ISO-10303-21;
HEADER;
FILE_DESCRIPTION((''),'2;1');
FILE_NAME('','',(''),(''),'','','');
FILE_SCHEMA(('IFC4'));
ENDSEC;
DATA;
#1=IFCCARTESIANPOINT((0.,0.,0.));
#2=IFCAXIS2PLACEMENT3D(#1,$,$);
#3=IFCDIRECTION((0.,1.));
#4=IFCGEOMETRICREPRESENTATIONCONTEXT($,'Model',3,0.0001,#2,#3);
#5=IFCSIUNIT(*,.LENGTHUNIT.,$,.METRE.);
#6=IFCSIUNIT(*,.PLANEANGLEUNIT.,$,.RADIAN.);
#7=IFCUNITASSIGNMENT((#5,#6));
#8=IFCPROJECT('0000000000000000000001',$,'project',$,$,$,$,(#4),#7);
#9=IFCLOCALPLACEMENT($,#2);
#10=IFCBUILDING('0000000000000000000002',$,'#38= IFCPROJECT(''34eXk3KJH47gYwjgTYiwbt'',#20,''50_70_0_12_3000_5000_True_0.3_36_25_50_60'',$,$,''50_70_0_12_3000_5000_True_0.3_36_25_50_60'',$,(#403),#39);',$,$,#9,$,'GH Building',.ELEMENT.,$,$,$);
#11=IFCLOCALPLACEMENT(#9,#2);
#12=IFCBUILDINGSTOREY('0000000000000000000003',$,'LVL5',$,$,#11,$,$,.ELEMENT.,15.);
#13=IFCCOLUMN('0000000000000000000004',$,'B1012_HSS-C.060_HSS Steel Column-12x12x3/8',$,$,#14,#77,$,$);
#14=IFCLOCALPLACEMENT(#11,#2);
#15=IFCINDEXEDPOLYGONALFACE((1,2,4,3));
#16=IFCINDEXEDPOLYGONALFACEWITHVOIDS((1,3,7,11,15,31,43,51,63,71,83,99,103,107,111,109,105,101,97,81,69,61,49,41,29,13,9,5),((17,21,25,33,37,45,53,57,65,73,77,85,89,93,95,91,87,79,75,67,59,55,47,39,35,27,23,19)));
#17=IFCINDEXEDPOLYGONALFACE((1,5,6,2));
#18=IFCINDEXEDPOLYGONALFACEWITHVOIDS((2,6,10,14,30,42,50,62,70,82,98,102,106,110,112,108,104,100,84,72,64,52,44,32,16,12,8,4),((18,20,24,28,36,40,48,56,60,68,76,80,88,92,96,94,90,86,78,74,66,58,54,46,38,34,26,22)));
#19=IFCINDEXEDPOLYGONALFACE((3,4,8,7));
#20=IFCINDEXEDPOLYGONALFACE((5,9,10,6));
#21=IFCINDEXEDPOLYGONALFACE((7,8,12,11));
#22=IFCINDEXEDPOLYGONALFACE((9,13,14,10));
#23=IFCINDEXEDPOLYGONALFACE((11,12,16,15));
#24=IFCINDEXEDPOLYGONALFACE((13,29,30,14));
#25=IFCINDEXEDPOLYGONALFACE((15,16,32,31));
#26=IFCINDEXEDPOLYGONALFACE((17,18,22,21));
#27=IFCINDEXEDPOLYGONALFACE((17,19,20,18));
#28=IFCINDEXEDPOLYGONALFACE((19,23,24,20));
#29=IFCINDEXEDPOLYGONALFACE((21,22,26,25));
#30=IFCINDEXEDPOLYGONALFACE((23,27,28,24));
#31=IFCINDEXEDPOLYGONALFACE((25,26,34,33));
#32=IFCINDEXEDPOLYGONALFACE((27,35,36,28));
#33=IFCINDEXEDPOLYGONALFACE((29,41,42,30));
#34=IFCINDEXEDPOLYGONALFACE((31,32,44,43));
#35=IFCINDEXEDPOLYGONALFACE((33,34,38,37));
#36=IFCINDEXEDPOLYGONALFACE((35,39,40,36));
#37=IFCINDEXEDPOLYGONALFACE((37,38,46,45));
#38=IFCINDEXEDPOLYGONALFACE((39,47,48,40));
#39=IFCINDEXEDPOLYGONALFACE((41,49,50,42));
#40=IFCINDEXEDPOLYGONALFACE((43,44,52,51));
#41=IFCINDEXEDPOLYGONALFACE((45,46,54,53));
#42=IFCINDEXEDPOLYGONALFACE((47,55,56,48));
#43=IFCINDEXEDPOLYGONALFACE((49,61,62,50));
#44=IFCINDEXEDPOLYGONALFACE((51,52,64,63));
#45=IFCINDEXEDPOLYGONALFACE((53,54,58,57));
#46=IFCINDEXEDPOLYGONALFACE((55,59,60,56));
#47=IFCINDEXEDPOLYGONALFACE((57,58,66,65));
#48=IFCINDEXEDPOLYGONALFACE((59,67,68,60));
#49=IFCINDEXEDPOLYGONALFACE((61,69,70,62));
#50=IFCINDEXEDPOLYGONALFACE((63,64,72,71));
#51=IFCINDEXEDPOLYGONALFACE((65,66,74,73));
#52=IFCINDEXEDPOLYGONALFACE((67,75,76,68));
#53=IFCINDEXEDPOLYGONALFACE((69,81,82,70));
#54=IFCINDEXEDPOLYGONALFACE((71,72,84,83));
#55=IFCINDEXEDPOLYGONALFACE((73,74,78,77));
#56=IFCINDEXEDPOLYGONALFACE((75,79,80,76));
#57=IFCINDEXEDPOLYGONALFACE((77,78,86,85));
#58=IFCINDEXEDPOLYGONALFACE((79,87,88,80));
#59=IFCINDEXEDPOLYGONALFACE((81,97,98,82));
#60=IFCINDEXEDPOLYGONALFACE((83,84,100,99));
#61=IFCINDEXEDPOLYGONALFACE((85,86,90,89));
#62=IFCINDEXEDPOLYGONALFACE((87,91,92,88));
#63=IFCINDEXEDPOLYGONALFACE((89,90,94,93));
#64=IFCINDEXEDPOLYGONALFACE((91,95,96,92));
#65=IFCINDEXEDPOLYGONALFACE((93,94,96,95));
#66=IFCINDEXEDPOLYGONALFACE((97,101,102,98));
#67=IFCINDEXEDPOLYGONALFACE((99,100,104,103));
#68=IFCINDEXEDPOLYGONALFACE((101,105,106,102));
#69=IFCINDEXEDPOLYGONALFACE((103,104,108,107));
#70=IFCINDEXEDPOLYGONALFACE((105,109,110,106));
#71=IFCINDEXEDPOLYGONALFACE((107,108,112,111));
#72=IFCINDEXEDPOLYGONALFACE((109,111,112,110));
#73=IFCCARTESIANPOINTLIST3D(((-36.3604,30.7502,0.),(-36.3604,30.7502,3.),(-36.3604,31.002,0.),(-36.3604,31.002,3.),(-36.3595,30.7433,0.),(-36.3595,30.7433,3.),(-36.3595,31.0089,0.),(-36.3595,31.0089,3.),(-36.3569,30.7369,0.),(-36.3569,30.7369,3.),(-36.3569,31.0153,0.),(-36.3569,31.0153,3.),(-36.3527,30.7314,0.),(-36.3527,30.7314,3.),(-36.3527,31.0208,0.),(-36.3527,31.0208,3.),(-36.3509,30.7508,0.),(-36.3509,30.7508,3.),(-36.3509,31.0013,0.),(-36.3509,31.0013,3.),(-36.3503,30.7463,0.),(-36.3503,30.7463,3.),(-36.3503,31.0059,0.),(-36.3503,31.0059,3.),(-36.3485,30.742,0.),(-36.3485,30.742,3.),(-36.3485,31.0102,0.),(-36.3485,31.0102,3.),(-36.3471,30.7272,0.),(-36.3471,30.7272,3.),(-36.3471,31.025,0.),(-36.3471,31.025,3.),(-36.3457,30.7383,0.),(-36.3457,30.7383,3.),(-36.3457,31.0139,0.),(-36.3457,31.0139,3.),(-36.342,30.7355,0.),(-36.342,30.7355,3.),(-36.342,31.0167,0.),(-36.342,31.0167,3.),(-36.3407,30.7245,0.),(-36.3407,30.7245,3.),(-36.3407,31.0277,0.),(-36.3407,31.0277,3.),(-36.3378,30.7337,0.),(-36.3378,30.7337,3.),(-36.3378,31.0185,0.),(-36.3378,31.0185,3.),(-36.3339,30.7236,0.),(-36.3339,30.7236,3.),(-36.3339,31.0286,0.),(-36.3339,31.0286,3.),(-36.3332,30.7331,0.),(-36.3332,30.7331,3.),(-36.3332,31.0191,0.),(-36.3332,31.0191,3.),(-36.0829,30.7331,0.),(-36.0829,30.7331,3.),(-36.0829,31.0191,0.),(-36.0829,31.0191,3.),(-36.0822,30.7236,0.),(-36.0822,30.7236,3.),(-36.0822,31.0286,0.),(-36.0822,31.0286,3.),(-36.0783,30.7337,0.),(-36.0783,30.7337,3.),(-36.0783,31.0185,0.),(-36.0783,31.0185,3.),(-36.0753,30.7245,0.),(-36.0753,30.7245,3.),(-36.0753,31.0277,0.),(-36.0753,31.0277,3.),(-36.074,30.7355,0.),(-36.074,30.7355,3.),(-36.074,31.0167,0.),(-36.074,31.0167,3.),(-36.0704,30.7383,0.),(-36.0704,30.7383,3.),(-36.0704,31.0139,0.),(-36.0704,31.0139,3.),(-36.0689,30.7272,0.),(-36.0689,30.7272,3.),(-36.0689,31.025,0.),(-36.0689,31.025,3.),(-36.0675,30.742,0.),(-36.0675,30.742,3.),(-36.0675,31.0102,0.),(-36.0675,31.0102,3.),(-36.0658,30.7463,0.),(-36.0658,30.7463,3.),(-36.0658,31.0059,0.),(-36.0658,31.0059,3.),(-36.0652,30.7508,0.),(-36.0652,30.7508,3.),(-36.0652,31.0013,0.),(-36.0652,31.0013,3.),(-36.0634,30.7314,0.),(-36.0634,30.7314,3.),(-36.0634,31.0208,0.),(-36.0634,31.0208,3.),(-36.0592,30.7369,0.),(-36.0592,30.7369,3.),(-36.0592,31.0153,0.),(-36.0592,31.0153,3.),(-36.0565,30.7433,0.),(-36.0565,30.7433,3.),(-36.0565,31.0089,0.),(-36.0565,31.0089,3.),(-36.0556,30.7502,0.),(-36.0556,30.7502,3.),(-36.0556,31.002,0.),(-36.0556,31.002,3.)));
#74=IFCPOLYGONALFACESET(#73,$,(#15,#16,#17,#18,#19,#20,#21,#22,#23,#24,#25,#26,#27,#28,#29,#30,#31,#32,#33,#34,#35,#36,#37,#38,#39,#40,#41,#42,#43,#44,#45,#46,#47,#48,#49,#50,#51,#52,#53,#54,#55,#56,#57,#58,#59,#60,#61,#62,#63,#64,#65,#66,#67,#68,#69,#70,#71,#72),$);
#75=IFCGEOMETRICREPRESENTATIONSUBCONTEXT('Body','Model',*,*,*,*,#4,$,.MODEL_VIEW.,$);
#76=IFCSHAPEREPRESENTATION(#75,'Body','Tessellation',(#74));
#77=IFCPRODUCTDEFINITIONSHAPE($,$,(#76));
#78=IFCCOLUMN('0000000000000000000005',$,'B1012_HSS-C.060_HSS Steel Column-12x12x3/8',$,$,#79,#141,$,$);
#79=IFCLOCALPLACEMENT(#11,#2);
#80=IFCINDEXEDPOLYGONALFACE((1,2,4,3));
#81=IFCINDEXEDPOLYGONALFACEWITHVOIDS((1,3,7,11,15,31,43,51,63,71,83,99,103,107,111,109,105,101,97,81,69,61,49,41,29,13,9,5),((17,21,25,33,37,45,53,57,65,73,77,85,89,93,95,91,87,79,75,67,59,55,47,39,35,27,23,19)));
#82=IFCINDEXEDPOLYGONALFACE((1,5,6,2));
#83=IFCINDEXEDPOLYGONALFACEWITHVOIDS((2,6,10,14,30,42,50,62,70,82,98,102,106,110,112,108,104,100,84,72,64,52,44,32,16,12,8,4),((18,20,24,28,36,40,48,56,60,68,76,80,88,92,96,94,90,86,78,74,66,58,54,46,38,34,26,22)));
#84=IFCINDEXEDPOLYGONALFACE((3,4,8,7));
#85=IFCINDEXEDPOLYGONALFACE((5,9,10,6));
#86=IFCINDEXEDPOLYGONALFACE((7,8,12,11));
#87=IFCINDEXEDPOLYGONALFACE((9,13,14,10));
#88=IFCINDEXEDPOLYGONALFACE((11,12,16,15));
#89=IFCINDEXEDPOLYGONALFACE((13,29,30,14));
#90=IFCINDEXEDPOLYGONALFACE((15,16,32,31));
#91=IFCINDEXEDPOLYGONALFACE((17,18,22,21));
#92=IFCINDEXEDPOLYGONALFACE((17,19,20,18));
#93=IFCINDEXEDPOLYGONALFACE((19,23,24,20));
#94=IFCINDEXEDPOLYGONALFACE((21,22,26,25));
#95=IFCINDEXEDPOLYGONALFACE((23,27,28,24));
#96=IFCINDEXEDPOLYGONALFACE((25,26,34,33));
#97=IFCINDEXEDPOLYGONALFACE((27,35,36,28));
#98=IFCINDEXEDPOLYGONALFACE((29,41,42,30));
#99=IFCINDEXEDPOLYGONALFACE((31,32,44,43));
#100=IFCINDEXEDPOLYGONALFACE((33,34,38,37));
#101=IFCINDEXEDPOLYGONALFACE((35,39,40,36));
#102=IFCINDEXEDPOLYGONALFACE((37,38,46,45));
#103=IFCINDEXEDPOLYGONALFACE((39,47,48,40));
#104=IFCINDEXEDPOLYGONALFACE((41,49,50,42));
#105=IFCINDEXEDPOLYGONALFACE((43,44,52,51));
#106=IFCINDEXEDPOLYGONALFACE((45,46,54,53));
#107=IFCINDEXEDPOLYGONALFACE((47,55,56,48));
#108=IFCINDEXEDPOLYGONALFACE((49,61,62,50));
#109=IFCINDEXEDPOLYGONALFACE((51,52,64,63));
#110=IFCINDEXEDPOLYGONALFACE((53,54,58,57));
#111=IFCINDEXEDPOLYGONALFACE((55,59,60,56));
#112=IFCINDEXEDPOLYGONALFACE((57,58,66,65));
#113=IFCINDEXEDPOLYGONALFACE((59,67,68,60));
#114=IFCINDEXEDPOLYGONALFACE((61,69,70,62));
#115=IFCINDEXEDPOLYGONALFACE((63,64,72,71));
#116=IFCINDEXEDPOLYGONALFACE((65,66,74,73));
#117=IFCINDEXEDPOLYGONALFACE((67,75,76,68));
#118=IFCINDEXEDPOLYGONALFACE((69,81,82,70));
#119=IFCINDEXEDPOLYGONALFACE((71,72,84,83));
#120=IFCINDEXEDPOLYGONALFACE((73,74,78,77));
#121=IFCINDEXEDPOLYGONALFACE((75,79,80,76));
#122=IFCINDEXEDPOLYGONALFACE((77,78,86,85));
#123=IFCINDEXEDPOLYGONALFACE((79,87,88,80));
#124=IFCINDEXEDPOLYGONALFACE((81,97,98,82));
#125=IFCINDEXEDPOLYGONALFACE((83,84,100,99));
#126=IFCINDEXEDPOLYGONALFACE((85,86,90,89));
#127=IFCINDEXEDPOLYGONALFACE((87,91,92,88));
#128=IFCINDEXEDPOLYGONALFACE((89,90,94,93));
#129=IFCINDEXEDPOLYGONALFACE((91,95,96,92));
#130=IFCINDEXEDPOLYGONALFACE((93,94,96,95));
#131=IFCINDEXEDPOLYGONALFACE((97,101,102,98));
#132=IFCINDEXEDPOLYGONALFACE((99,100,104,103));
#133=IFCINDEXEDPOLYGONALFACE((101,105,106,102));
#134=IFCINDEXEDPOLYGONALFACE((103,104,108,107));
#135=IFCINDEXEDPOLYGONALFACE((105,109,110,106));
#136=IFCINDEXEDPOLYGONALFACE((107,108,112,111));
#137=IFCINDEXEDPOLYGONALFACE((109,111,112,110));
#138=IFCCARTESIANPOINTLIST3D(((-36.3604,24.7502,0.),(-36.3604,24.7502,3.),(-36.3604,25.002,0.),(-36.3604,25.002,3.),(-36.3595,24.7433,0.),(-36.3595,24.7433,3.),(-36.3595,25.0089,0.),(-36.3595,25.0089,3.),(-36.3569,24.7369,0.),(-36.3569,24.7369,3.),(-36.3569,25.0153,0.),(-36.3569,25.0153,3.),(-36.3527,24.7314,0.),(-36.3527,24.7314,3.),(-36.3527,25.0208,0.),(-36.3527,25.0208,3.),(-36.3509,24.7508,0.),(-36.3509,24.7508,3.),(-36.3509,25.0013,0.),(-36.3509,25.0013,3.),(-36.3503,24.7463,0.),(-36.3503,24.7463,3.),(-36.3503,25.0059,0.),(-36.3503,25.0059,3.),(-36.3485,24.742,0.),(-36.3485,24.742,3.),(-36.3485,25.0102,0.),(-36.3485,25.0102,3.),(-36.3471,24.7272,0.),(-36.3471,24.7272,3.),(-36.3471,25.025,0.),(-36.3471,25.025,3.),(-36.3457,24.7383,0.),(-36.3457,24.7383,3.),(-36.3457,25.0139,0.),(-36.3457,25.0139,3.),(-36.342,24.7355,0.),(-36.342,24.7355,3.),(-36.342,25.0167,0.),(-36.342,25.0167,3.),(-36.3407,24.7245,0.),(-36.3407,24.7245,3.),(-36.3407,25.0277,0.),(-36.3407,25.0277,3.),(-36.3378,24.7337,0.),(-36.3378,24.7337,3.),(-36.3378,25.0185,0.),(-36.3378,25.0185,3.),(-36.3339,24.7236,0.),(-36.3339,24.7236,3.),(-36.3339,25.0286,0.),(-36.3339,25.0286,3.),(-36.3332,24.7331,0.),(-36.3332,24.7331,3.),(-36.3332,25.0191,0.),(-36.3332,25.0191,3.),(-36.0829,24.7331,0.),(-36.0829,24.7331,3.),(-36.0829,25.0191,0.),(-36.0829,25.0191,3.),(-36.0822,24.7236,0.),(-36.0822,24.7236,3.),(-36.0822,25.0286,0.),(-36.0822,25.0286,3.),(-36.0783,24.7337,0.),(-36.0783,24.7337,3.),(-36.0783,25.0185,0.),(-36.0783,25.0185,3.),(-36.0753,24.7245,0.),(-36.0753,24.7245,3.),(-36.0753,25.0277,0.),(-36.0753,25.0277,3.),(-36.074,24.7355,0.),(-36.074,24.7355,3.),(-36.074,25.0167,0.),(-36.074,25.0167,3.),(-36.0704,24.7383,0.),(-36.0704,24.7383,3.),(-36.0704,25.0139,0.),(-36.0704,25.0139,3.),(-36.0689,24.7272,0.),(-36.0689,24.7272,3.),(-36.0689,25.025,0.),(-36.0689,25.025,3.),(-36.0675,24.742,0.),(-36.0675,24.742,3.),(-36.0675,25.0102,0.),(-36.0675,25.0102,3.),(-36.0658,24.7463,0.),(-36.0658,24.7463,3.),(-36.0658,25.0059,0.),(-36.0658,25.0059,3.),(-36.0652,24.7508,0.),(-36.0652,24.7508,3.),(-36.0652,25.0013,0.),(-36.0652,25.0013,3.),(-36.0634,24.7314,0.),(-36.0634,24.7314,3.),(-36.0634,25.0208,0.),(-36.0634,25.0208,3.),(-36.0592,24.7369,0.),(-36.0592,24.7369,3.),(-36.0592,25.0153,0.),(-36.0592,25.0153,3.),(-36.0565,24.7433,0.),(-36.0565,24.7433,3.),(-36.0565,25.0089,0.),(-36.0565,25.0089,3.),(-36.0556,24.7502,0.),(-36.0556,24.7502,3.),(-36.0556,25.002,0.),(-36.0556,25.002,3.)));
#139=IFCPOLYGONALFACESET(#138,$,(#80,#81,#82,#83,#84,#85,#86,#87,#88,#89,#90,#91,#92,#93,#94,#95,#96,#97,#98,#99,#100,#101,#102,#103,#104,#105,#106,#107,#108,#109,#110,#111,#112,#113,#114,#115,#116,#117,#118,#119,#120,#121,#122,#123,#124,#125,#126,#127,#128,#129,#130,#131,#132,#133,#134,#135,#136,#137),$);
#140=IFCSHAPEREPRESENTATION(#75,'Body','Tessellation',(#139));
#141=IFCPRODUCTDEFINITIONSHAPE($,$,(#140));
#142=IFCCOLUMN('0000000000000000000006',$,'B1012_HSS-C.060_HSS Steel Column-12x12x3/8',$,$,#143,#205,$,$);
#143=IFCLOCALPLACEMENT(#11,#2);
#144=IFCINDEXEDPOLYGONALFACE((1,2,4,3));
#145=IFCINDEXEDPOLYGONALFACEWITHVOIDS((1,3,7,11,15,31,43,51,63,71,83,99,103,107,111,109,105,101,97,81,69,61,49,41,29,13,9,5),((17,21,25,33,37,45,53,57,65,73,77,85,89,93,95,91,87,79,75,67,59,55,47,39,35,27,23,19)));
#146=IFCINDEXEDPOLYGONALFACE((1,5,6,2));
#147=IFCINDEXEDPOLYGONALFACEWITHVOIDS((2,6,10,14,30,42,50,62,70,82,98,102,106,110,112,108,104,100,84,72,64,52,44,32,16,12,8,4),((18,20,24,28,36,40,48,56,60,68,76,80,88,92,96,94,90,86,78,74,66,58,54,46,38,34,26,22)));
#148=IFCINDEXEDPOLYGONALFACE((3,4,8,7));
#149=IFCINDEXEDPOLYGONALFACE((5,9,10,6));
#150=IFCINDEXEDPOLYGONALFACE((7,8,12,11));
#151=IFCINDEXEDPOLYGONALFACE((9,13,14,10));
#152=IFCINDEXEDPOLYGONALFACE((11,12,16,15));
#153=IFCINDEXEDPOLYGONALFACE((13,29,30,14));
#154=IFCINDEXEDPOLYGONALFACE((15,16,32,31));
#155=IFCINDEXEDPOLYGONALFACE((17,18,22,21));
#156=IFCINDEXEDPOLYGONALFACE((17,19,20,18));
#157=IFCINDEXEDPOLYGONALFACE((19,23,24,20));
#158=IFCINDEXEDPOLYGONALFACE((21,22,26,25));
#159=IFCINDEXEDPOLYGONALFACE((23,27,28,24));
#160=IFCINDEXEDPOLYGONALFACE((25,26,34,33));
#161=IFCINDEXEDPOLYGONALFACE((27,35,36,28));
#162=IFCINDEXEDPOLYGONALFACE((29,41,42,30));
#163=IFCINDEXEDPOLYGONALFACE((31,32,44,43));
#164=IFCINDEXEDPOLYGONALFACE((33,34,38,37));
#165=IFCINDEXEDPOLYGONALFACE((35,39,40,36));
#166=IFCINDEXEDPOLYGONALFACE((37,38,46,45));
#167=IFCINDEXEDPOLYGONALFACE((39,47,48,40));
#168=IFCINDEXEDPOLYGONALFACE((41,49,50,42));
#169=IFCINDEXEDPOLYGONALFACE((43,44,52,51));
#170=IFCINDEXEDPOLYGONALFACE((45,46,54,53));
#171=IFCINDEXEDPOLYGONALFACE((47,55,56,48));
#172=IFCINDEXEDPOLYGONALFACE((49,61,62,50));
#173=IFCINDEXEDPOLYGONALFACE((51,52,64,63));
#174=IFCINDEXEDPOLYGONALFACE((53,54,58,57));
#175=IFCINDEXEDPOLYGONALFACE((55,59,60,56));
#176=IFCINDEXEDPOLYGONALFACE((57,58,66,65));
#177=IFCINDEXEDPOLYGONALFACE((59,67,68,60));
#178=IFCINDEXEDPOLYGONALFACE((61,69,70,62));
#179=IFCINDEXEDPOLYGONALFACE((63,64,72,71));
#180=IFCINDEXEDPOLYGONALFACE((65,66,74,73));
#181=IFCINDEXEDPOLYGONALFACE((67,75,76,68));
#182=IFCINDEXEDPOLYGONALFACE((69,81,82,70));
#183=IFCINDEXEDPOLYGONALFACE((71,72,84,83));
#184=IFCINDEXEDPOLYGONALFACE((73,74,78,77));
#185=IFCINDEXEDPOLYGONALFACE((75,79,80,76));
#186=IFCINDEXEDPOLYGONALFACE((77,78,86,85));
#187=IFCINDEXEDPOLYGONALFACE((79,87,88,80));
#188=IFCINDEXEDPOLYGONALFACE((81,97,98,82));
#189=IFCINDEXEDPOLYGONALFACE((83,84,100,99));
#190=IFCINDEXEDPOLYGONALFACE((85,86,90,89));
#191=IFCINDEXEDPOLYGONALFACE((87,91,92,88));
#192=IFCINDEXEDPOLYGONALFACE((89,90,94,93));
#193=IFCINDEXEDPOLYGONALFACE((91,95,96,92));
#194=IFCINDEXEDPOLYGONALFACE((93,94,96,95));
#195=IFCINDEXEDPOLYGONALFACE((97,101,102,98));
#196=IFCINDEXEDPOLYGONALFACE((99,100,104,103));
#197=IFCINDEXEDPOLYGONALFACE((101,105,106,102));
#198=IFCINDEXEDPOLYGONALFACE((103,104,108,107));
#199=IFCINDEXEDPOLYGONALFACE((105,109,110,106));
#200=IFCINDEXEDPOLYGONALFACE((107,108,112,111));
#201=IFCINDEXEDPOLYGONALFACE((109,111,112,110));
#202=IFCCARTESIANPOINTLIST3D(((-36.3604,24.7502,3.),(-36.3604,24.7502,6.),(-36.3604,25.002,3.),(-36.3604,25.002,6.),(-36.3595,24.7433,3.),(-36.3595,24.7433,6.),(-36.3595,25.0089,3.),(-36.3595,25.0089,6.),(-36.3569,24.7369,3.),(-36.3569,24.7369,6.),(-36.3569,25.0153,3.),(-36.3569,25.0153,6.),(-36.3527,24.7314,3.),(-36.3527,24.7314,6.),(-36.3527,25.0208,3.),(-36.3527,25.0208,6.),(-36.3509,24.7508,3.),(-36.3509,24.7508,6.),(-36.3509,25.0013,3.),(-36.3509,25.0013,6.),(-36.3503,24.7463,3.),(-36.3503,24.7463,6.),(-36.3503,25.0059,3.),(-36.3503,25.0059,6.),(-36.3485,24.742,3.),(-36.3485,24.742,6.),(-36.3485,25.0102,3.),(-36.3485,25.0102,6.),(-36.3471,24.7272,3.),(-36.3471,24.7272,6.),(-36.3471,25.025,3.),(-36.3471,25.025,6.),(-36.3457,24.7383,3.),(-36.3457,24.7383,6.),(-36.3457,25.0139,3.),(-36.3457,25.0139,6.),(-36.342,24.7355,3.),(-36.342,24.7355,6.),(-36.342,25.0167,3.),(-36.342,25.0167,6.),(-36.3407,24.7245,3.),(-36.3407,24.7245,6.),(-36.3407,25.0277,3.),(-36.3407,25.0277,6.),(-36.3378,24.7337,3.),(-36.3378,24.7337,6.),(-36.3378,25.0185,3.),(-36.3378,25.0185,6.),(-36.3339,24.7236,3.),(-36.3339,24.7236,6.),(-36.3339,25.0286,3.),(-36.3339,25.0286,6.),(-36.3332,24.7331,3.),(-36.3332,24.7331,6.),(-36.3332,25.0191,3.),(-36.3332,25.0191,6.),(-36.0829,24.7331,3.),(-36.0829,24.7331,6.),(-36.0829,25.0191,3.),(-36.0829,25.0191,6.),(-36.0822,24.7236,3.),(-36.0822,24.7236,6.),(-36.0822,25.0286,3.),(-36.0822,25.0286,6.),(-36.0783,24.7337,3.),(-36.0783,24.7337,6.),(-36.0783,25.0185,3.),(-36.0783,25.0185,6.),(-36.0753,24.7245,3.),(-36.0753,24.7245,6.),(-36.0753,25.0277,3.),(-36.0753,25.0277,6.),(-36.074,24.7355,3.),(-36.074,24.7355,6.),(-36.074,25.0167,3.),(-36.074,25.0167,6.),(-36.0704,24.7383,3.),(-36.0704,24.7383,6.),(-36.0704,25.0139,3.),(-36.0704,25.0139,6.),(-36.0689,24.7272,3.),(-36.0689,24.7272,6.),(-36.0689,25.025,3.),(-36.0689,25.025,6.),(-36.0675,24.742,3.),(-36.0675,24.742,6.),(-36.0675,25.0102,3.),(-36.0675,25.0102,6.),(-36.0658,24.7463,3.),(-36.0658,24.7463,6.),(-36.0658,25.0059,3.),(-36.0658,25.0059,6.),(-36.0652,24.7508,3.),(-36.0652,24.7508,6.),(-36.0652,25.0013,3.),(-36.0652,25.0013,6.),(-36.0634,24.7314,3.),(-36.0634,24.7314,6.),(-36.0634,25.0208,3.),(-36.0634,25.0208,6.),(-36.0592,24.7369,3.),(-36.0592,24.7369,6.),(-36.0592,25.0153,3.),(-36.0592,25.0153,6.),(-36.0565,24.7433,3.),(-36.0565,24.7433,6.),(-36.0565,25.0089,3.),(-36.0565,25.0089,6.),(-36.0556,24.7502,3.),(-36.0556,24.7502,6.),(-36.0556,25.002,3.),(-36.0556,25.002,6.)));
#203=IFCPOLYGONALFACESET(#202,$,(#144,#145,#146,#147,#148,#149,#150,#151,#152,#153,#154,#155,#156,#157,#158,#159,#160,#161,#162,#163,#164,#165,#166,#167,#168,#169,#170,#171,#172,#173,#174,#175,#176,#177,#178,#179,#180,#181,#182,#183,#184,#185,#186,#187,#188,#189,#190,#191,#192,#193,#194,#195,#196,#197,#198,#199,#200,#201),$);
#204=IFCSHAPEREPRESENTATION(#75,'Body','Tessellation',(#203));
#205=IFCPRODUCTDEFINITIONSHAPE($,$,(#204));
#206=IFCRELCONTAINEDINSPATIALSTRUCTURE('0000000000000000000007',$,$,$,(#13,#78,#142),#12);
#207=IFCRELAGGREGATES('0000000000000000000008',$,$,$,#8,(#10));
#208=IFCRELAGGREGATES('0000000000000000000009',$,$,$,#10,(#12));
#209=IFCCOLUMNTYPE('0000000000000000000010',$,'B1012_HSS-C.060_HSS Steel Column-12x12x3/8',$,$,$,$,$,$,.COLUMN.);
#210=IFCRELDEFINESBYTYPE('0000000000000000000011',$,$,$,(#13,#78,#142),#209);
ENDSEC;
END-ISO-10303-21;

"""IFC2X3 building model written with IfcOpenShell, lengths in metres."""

from ifc_helpers import new_model, si_unit, direction, frame, origin, origin_2d, place, context, subcontext, project, spatial, hollow_rectangle, extrude, type_object, element, save


model = new_model("IFC2X3")

# Units and contexts
model_context = context("Model", 3, precision=0.0001, world=origin(), true_north=direction((0.0, 1.0)))
body_context = subcontext(model_context, "Body", "Model", "MODEL_VIEW")
ifc_project = project(units=[si_unit("LENGTHUNIT", "METRE"), si_unit("PLANEANGLEUNIT", "RADIAN")], contexts=[model_context])

# Building, storey
building_placement = place(None, origin())
building = spatial("IfcBuilding", under=ifc_project, at=building_placement, Name="#38= IFCPROJECT('34eXk3KJH47gYwjgTYiwbt',#20,'50_70_0_12_3000_5000_True_0.3_36_25_50_60',$,$,'50_70_0_12_3000_5000_True_0.3_36_25_50_60',$,(#403),#39);", LongName="GH Building", CompositionType="ELEMENT")
storey_placement = place(building_placement, origin())
storey = spatial("IfcBuildingStorey", under=building, at=storey_placement, Name="LVL5", CompositionType="ELEMENT", Elevation=15.0)

# Columns
column_type = type_object("IfcColumnType", Name="B1012_HSS-C.060_HSS Steel Column-12x12x3/8", PredefinedType="COLUMN")
for number, where, z_axis, x_axis, name in (
    (1, (-36.208, 30.8761, 3.0), (0.0, 0.0, -1.0), (-1.0, 0.0, 0.0), "B1012_HSS-C.060_HSS Steel Column-12x12x3/8"),
    (2, (-36.208, 24.8761, 3.0), (0.0, 0.0, -1.0), (-1.0, 0.0, 0.0), "B1012_HSS-C.060_HSS Steel Column-12x12x3/8"),
    (3, (-36.208, 24.8761, 6.0), (0.0, 0.0, -1.0), (-1.0, 0.0, 0.0), "B1012_HSS-C.060_HSS Steel Column-12x12x3/8"),
):
    element("IfcColumn", number, at=place(storey_placement, frame(where, z_axis=z_axis, x_axis=x_axis)), inside=storey, type_object=column_type, Name=name, context=body_context, shape_type="SweptSolid", body=[
        extrude(hollow_rectangle(XDim=0.3048, YDim=0.305, WallThickness=0.0095, InnerFilletRadius=0.0177, OuterFilletRadius=0.0266, at=origin_2d()), origin(), (0.0, 0.0, 1.0), 3.0),
    ])

save(model, "model.ifc")
